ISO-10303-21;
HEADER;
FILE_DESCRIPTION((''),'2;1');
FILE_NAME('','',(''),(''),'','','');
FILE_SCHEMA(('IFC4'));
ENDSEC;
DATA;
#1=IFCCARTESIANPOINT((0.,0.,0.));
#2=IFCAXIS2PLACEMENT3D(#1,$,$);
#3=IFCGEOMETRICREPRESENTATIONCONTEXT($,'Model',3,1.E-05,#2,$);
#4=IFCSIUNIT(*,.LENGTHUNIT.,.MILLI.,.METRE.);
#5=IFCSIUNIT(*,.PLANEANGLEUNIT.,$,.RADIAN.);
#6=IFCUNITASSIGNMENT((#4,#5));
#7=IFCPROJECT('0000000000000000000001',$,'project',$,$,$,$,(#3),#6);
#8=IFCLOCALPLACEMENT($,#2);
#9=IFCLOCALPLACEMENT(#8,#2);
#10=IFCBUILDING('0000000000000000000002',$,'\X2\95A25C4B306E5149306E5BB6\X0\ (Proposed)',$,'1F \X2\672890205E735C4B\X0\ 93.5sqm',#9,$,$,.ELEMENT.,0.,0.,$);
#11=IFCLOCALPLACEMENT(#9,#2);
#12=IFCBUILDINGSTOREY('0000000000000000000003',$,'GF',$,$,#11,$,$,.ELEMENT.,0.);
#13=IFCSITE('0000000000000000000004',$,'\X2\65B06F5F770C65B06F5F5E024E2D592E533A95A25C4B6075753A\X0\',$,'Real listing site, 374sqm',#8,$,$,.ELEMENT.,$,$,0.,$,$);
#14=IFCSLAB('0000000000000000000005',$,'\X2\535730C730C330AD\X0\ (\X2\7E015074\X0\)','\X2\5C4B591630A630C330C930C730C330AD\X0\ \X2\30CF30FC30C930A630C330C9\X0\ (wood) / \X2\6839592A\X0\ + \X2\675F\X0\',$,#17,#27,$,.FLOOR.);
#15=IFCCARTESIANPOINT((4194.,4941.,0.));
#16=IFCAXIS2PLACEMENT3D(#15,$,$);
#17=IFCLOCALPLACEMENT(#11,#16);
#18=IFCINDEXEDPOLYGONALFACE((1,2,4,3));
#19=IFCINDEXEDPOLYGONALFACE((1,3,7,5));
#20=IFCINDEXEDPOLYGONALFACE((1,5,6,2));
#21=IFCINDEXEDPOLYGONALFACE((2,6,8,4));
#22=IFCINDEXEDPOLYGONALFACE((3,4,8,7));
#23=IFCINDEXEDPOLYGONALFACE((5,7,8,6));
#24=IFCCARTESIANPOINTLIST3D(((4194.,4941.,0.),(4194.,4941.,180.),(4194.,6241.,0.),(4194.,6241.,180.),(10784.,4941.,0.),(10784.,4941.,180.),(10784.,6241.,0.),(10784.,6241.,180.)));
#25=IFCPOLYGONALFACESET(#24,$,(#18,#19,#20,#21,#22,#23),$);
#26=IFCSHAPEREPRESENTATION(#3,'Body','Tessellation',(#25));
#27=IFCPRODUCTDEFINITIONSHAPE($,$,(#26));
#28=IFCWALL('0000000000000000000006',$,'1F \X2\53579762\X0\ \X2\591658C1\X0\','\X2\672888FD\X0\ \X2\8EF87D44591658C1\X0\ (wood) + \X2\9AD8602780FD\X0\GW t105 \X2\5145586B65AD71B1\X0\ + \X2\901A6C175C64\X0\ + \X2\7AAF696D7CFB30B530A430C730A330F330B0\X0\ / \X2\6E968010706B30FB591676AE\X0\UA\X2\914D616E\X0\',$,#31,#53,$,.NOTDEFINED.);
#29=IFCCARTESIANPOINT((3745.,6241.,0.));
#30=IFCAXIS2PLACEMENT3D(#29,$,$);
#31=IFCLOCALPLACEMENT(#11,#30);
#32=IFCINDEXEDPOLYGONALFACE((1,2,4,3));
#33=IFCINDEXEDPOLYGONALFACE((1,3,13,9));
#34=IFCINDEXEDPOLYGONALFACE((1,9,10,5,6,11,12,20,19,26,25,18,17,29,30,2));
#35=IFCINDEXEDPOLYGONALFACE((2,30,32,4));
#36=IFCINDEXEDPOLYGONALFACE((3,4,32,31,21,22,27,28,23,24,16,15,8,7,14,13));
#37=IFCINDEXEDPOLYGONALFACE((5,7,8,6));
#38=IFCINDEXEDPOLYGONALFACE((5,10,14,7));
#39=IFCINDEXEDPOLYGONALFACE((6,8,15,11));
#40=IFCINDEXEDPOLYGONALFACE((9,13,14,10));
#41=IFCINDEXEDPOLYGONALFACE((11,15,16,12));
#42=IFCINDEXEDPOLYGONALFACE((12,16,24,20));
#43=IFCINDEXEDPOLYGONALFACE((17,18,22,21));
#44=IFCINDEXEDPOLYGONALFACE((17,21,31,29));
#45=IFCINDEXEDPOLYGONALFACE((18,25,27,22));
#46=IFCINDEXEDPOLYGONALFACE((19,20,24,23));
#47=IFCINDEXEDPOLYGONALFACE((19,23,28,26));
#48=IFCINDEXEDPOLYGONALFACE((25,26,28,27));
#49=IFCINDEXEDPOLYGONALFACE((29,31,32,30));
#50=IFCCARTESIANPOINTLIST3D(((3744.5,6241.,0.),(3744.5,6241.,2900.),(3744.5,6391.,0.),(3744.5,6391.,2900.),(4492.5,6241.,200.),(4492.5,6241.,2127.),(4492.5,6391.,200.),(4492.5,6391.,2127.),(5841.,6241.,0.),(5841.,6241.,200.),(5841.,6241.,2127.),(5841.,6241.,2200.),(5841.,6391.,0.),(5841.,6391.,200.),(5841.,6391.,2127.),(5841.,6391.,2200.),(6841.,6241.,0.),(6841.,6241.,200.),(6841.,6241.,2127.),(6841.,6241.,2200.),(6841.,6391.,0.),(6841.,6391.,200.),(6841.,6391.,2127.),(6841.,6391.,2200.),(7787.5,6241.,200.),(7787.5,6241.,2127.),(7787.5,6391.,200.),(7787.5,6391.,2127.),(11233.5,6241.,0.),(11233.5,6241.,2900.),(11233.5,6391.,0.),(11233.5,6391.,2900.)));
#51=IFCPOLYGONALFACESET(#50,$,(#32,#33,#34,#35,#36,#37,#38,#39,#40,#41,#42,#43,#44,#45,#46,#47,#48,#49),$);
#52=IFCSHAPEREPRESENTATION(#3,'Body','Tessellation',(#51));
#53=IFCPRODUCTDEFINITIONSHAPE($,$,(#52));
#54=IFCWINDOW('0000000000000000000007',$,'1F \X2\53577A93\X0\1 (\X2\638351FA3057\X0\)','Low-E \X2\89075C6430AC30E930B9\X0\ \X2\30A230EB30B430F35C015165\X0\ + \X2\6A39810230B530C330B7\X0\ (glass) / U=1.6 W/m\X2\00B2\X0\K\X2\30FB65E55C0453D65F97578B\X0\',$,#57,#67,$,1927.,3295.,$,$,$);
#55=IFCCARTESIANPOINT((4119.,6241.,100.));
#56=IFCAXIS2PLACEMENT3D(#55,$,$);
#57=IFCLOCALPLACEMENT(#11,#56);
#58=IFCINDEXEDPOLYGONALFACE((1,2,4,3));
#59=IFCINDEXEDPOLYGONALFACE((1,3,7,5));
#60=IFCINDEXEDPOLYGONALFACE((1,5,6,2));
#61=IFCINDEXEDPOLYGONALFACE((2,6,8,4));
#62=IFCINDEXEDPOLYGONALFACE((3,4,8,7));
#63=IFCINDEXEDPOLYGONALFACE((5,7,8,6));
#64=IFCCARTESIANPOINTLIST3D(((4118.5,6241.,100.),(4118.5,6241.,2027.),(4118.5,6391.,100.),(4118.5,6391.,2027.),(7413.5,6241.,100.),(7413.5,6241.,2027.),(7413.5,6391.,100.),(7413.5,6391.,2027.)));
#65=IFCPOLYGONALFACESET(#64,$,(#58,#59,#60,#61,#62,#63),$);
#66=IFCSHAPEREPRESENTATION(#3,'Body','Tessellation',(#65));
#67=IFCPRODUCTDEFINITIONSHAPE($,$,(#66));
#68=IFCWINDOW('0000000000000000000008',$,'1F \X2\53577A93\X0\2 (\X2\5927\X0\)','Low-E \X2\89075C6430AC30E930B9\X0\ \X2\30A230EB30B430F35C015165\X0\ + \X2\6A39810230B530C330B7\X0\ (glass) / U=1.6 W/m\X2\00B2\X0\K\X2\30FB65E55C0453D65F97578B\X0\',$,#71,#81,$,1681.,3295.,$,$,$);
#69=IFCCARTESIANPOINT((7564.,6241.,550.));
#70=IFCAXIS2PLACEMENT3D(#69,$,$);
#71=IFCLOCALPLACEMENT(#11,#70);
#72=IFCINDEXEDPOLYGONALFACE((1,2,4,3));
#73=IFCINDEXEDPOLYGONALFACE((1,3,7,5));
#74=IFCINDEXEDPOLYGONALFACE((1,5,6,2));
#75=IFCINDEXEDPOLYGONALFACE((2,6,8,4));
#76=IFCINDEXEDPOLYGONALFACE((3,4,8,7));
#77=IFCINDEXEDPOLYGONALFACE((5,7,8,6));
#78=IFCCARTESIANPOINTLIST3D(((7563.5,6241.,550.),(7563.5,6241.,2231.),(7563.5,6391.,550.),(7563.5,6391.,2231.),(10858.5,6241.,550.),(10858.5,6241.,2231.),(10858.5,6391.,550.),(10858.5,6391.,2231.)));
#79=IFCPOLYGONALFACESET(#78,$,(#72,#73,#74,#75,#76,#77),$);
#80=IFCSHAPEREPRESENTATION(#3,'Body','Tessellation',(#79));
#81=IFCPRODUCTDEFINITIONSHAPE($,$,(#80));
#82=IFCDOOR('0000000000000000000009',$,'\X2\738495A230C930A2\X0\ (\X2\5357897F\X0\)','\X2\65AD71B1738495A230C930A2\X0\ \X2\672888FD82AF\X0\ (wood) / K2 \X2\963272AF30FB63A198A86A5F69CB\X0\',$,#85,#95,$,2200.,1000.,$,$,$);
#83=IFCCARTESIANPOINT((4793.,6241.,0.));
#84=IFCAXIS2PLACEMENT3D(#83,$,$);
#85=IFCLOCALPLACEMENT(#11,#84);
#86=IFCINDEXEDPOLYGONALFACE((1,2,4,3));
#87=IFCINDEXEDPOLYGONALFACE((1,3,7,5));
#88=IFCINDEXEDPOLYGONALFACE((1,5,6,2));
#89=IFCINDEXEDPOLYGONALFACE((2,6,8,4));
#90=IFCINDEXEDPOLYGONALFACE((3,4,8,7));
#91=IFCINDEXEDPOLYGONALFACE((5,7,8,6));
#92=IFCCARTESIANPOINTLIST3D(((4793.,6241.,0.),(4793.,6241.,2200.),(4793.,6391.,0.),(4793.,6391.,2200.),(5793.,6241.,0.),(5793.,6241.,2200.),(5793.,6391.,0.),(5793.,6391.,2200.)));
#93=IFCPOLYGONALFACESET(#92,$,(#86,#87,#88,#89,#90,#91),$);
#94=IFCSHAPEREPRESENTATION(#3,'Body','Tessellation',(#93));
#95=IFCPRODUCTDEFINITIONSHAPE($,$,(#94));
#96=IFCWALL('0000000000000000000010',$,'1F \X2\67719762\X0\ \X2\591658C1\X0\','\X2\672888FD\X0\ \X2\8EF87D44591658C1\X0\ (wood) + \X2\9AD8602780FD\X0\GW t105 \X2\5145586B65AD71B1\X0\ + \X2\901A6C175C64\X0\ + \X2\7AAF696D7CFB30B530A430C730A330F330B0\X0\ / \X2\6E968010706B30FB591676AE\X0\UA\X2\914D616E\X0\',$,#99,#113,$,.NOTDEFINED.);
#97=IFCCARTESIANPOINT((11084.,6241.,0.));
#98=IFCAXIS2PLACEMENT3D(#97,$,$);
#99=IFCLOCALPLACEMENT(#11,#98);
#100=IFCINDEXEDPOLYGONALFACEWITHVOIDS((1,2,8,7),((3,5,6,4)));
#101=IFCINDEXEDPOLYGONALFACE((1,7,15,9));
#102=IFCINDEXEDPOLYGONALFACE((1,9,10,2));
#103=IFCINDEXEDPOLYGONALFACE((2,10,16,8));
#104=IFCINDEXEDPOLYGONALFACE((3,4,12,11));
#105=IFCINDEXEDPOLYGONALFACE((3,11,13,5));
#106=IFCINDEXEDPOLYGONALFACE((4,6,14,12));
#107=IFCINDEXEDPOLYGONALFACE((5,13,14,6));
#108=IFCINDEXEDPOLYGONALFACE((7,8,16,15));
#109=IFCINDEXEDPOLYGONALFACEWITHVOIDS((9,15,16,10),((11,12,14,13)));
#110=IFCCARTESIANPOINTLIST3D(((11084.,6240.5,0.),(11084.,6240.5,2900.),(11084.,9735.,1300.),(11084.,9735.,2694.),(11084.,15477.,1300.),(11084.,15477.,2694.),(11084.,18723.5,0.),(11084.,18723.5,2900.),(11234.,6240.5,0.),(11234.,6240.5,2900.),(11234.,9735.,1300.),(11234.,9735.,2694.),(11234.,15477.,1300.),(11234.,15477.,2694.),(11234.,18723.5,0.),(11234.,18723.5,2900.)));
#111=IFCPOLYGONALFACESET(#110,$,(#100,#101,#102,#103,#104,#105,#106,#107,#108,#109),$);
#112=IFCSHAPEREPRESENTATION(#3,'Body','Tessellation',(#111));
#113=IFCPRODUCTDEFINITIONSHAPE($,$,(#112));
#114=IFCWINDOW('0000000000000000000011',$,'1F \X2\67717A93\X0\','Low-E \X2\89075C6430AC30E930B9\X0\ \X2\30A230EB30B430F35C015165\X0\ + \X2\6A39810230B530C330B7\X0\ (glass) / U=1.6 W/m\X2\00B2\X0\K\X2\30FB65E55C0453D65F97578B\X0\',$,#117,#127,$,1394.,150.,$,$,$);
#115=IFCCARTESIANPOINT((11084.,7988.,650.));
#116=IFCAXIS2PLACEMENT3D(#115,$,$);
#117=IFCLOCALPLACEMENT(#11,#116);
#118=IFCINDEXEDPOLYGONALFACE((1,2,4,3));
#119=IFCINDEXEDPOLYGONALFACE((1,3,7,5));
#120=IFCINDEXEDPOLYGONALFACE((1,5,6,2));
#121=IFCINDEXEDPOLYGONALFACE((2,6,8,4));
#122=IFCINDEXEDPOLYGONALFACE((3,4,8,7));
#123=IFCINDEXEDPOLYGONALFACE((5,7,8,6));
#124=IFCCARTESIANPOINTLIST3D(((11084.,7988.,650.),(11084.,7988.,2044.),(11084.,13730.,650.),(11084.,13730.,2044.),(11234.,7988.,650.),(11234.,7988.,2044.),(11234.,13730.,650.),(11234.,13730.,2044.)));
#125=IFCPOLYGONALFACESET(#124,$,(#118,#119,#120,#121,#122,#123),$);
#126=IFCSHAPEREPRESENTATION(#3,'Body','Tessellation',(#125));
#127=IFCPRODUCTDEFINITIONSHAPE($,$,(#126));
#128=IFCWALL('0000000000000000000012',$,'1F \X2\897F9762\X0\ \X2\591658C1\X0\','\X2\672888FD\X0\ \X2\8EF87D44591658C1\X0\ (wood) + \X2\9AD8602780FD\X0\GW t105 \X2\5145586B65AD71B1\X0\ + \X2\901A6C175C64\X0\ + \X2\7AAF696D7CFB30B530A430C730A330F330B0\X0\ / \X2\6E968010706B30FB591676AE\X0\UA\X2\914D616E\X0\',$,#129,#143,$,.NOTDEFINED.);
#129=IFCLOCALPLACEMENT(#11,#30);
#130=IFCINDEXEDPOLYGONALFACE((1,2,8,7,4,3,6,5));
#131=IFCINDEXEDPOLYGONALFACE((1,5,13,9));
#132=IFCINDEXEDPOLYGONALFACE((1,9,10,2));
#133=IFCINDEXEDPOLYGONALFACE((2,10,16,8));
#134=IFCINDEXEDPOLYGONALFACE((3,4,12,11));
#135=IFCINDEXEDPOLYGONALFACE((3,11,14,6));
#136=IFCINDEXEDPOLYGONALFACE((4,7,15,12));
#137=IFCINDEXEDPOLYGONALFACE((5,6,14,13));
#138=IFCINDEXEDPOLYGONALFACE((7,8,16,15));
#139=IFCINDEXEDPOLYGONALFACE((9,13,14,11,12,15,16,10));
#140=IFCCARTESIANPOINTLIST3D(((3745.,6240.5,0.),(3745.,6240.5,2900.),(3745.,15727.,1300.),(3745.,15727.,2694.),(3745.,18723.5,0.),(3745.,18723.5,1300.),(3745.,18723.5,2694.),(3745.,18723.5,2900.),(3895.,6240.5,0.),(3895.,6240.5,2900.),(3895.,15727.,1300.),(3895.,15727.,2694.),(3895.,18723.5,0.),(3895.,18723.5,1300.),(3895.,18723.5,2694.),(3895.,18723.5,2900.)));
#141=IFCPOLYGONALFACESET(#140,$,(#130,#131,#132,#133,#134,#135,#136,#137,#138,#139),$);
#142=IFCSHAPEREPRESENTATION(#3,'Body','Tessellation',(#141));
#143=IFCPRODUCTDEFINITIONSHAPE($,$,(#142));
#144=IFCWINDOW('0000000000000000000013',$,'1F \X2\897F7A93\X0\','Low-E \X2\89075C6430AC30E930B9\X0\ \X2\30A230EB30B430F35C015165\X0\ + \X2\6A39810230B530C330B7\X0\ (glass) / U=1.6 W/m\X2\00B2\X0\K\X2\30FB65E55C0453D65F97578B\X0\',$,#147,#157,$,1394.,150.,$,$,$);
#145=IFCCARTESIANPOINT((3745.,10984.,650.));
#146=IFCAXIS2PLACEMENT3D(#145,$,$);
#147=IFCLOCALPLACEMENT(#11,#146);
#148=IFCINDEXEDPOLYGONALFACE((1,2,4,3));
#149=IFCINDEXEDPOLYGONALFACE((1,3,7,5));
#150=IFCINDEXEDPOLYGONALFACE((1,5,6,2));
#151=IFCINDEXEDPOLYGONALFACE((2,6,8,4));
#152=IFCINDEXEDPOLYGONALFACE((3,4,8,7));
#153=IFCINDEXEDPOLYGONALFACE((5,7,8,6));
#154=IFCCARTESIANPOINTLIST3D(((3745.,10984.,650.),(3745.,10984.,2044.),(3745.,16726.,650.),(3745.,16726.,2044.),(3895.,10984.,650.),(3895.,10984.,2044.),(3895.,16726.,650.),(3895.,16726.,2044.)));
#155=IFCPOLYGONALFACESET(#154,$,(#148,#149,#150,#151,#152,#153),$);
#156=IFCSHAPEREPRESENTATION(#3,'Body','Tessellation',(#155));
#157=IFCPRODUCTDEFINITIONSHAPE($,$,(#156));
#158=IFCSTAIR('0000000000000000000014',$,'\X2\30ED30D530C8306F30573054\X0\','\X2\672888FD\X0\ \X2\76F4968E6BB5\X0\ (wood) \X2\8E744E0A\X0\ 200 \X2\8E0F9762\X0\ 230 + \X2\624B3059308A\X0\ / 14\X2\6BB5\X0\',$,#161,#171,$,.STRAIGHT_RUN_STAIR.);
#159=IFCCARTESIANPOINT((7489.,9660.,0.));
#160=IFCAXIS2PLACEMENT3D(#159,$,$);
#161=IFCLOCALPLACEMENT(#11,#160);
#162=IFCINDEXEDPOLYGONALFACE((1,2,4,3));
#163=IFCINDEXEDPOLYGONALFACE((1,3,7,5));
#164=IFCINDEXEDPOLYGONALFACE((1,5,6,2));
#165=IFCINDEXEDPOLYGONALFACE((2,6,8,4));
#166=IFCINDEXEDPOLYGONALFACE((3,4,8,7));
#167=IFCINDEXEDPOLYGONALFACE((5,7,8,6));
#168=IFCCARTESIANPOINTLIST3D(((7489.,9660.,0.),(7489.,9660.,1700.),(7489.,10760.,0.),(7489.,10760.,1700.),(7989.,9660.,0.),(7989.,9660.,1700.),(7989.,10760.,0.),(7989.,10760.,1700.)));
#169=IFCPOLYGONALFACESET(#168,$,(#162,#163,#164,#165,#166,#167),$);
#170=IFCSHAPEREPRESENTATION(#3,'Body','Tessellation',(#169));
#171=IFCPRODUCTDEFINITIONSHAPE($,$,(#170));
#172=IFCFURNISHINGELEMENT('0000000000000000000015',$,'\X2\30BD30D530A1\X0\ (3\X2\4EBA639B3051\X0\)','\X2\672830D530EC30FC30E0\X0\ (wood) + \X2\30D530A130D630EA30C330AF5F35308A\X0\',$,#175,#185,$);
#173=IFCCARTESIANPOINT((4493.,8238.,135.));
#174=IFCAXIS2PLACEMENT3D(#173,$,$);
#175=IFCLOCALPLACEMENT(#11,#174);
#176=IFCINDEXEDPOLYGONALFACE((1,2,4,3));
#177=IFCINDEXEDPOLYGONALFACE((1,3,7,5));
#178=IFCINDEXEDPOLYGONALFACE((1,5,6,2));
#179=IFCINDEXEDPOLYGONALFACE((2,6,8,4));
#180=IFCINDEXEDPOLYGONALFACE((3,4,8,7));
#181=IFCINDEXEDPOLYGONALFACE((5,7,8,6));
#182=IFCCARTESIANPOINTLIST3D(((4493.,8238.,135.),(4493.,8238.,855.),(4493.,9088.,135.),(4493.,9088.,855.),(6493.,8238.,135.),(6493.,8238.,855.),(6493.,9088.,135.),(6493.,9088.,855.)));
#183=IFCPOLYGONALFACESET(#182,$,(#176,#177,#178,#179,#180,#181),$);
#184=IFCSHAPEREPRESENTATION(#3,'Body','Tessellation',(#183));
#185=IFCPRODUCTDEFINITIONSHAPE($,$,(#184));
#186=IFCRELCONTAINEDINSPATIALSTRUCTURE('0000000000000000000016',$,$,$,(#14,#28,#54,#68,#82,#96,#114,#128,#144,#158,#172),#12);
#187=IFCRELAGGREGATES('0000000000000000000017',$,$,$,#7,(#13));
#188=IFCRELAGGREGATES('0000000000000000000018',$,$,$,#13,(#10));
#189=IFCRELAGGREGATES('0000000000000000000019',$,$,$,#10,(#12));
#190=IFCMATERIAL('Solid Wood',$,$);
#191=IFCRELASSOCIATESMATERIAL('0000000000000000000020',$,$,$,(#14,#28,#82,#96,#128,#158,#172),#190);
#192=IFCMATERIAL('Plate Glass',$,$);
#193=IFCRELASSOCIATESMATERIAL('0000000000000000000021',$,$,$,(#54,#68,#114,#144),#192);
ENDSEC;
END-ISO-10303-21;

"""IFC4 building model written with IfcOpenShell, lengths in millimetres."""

from ifc_helpers import new_model, si_unit, frame, frame_2d, origin, place, context, project, spatial, rectangle, extrude, material, element, fill, save


model = new_model("IFC4")

# Units and contexts
model_context = context("Model", 3, precision=1e-05, world=origin())
ifc_project = project(units=[si_unit("LENGTHUNIT", "METRE", prefix="MILLI"), si_unit("PLANEANGLEUNIT", "RADIAN")], contexts=[model_context])

# Site, building, storey
site_placement = place(None, origin())
site = spatial("IfcSite", under=ifc_project, at=site_placement, Name="新潟県新潟市中央区関屋恵町", ObjectType="Real listing site, 374sqm", CompositionType="ELEMENT", RefElevation=0.0)
building_placement = place(site_placement, origin())
building = spatial("IfcBuilding", under=site, at=building_placement, Name="関屋の光の家 (Proposed)", ObjectType="1F 木造平屋 93.5sqm", CompositionType="ELEMENT", ElevationOfRefHeight=0.0, ElevationOfTerrain=0.0)
storey_placement = place(building_placement, origin())
storey = spatial("IfcBuildingStorey", under=building, at=storey_placement, Name="GF", CompositionType="ELEMENT", Elevation=0.0)

# Slab
ifc_material_1 = material(Name="Solid Wood")
slab_1_placement = place(storey_placement, frame((4194.0, 4941.0, 0.0)))
element("IfcSlab", 1, at=slab_1_placement, inside=storey, material=ifc_material_1, Name="南デッキ (縁側)", Description="屋外ウッドデッキ ハードウッド (wood) / 根太 + 束", PredefinedType="FLOOR", context=model_context, shape_type="SweptSolid", body=[
    extrude(rectangle(XDim=6590.0, YDim=1300.0, at=frame_2d((3295.0, 650.0))), frame((4194.0, 4941.0, 0.0)), (0.0, 0.0, 1.0), 180.0),
])

# Wall, openings, windows, door
wall_1_placement = place(storey_placement, frame((3745.0, 6241.0, 0.0)))
wall_1 = element("IfcWall", 2, at=wall_1_placement, inside=storey, material=ifc_material_1, Name="1F 南面 外壁", Description="木製 軸組外壁 (wood) + 高性能GW t105 充填断熱 + 通気層 + 窯業系サイディング / 準耐火・外皮UA配慮", PredefinedType="NOTDEFINED", context=model_context, shape_type="SweptSolid", body=[
    extrude(rectangle(XDim=7489.0, YDim=150.0, at=frame_2d((3744.0, 75.0))), frame((3745.0, 6241.0, 0.0)), (0.0, 0.0, 1.0), 2900.0),
])
opening_1_placement = place(storey_placement, frame((4119.0, 6241.0, 100.0)))
opening_1 = element("IfcOpeningElement", 3, at=opening_1_placement, cuts=wall_1, PredefinedType="NOTDEFINED", context=model_context, shape_type="SweptSolid", body=[
    extrude(rectangle(XDim=3295.0, YDim=150.0, at=frame_2d((1647.0, 75.0))), frame((4119.0, 6241.0, 100.0)), (0.0, 0.0, 1.0), 1927.0),
])
opening_2_placement = place(storey_placement, frame((7564.0, 6241.0, 550.0)))
opening_2 = element("IfcOpeningElement", 4, at=opening_2_placement, cuts=wall_1, PredefinedType="NOTDEFINED", context=model_context, shape_type="SweptSolid", body=[
    extrude(rectangle(XDim=3295.0, YDim=150.0, at=frame_2d((1647.0, 75.0))), frame((7564.0, 6241.0, 550.0)), (0.0, 0.0, 1.0), 1681.0),
])
opening_3_placement = place(storey_placement, frame((4793.0, 6241.0, 0.0)))
opening_3 = element("IfcOpeningElement", 5, at=opening_3_placement, cuts=wall_1, PredefinedType="NOTDEFINED", context=model_context, shape_type="SweptSolid", body=[
    extrude(rectangle(XDim=1000.0, YDim=150.0, at=frame_2d((500.0, 75.0))), frame((4793.0, 6241.0, 0.0)), (0.0, 0.0, 1.0), 2200.0),
])
ifc_material_2 = material(Name="Plate Glass")
window_1_placement = place(storey_placement, frame((4119.0, 6241.0, 100.0)))
window_1 = element("IfcWindow", 6, at=window_1_placement, inside=storey, material=ifc_material_2, Name="1F 南窓1 (掃出し)", Description="Low-E 複層ガラス アルゴン封入 + 樹脂サッシ (glass) / U=1.6 W/m²K・日射取得型", OverallHeight=1927.0, OverallWidth=3295.0, context=model_context, shape_type="SweptSolid", body=[
    extrude(rectangle(XDim=3295.0, YDim=150.0, at=frame_2d((1647.0, 75.0))), frame((4119.0, 6241.0, 100.0)), (0.0, 0.0, 1.0), 1927.0),
])
fill(opening_1, window_1)
window_2_placement = place(storey_placement, frame((7564.0, 6241.0, 550.0)))
window_2 = element("IfcWindow", 7, at=window_2_placement, inside=storey, material=ifc_material_2, Name="1F 南窓2 (大)", Description="Low-E 複層ガラス アルゴン封入 + 樹脂サッシ (glass) / U=1.6 W/m²K・日射取得型", OverallHeight=1681.0, OverallWidth=3295.0, context=model_context, shape_type="SweptSolid", body=[
    extrude(rectangle(XDim=3295.0, YDim=150.0, at=frame_2d((1647.0, 75.0))), frame((7564.0, 6241.0, 550.0)), (0.0, 0.0, 1.0), 1681.0),
])
fill(opening_2, window_2)
door_placement = place(storey_placement, frame((4793.0, 6241.0, 0.0)))
door = element("IfcDoor", 8, at=door_placement, inside=storey, material=ifc_material_1, Name="玄関ドア (南西)", Description="断熱玄関ドア 木製芯 (wood) / K2 防犯・採風機構", OverallHeight=2200.0, OverallWidth=1000.0, context=model_context, shape_type="SweptSolid", body=[
    extrude(rectangle(XDim=1000.0, YDim=150.0, at=frame_2d((500.0, 75.0))), frame((4793.0, 6241.0, 0.0)), (0.0, 0.0, 1.0), 2200.0),
])
fill(opening_3, door)

# Walls, openings, windows
wall_2_placement = place(storey_placement, frame((11084.0, 6241.0, 0.0)))
wall_2 = element("IfcWall", 9, at=wall_2_placement, inside=storey, material=ifc_material_1, Name="1F 東面 外壁", Description="木製 軸組外壁 (wood) + 高性能GW t105 充填断熱 + 通気層 + 窯業系サイディング / 準耐火・外皮UA配慮", PredefinedType="NOTDEFINED", context=model_context, shape_type="SweptSolid", body=[
    extrude(rectangle(XDim=150.0, YDim=12483.0, at=frame_2d((75.0, 6241.0))), frame((11084.0, 6241.0, 0.0)), (0.0, 0.0, 1.0), 2900.0),
])
opening_4_placement = place(storey_placement, frame((11084.0, 7988.0, 650.0)))
opening_4 = element("IfcOpeningElement", 10, at=opening_4_placement, cuts=wall_2, PredefinedType="NOTDEFINED", context=model_context, shape_type="SweptSolid", body=[
    extrude(rectangle(XDim=150.0, YDim=5742.0, at=frame_2d((75.0, 2871.0))), frame((11084.0, 7988.0, 650.0)), (0.0, 0.0, 1.0), 1394.0),
])
window_3_placement = place(storey_placement, frame((11084.0, 7988.0, 650.0)))
window_3 = element("IfcWindow", 11, at=window_3_placement, inside=storey, material=ifc_material_2, Name="1F 東窓", Description="Low-E 複層ガラス アルゴン封入 + 樹脂サッシ (glass) / U=1.6 W/m²K・日射取得型", OverallHeight=1394.0, OverallWidth=150.0, context=model_context, shape_type="SweptSolid", body=[
    extrude(rectangle(XDim=150.0, YDim=5742.0, at=frame_2d((75.0, 2871.0))), frame((11084.0, 7988.0, 650.0)), (0.0, 0.0, 1.0), 1394.0),
])
fill(opening_4, window_3)
wall_3_placement = place(storey_placement, frame((3745.0, 6241.0, 0.0)))
wall_3 = element("IfcWall", 12, at=wall_3_placement, inside=storey, material=ifc_material_1, Name="1F 西面 外壁", Description="木製 軸組外壁 (wood) + 高性能GW t105 充填断熱 + 通気層 + 窯業系サイディング / 準耐火・外皮UA配慮", PredefinedType="NOTDEFINED", context=model_context, shape_type="SweptSolid", body=[
    extrude(rectangle(XDim=150.0, YDim=12483.0, at=frame_2d((75.0, 6241.0))), frame((3745.0, 6241.0, 0.0)), (0.0, 0.0, 1.0), 2900.0),
])
opening_5_placement = place(storey_placement, frame((3745.0, 10984.0, 650.0)))
opening_5 = element("IfcOpeningElement", 13, at=opening_5_placement, cuts=wall_3, PredefinedType="NOTDEFINED", context=model_context, shape_type="SweptSolid", body=[
    extrude(rectangle(XDim=150.0, YDim=5742.0, at=frame_2d((75.0, 2871.0))), frame((3745.0, 10984.0, 650.0)), (0.0, 0.0, 1.0), 1394.0),
])
window_4_placement = place(storey_placement, frame((3745.0, 10984.0, 650.0)))
window_4 = element("IfcWindow", 14, at=window_4_placement, inside=storey, material=ifc_material_2, Name="1F 西窓", Description="Low-E 複層ガラス アルゴン封入 + 樹脂サッシ (glass) / U=1.6 W/m²K・日射取得型", OverallHeight=1394.0, OverallWidth=150.0, context=model_context, shape_type="SweptSolid", body=[
    extrude(rectangle(XDim=150.0, YDim=5742.0, at=frame_2d((75.0, 2871.0))), frame((3745.0, 10984.0, 650.0)), (0.0, 0.0, 1.0), 1394.0),
])
fill(opening_5, window_4)

# Stair
stair_placement = place(storey_placement, frame((7489.0, 9660.0, 0.0)))
element("IfcStair", 15, at=stair_placement, inside=storey, material=ifc_material_1, Name="ロフトはしご", Description="木製 直階段 (wood) 蹴上 200 踏面 230 + 手すり / 14段", PredefinedType="STRAIGHT_RUN_STAIR", context=model_context, shape_type="SweptSolid", body=[
    extrude(rectangle(XDim=500.0, YDim=1100.0, at=frame_2d((250.0, 550.0))), frame((7489.0, 9660.0, 0.0)), (0.0, 0.0, 1.0), 1700.0),
])

# Furnishing element
furnishing_1_placement = place(storey_placement, frame((4493.0, 8238.0, 135.0)))
element("IfcFurnishingElement", 16, at=furnishing_1_placement, inside=storey, material=ifc_material_1, Name="ソファ (3人掛け)", Description="木フレーム (wood) + ファブリック張り", context=model_context, shape_type="SweptSolid", body=[
    extrude(rectangle(XDim=2000.0, YDim=850.0, at=frame_2d((1000.0, 425.0))), frame((4493.0, 8238.0, 135.0)), (0.0, 0.0, 1.0), 720.0),
])

save(model, "model.ifc")
